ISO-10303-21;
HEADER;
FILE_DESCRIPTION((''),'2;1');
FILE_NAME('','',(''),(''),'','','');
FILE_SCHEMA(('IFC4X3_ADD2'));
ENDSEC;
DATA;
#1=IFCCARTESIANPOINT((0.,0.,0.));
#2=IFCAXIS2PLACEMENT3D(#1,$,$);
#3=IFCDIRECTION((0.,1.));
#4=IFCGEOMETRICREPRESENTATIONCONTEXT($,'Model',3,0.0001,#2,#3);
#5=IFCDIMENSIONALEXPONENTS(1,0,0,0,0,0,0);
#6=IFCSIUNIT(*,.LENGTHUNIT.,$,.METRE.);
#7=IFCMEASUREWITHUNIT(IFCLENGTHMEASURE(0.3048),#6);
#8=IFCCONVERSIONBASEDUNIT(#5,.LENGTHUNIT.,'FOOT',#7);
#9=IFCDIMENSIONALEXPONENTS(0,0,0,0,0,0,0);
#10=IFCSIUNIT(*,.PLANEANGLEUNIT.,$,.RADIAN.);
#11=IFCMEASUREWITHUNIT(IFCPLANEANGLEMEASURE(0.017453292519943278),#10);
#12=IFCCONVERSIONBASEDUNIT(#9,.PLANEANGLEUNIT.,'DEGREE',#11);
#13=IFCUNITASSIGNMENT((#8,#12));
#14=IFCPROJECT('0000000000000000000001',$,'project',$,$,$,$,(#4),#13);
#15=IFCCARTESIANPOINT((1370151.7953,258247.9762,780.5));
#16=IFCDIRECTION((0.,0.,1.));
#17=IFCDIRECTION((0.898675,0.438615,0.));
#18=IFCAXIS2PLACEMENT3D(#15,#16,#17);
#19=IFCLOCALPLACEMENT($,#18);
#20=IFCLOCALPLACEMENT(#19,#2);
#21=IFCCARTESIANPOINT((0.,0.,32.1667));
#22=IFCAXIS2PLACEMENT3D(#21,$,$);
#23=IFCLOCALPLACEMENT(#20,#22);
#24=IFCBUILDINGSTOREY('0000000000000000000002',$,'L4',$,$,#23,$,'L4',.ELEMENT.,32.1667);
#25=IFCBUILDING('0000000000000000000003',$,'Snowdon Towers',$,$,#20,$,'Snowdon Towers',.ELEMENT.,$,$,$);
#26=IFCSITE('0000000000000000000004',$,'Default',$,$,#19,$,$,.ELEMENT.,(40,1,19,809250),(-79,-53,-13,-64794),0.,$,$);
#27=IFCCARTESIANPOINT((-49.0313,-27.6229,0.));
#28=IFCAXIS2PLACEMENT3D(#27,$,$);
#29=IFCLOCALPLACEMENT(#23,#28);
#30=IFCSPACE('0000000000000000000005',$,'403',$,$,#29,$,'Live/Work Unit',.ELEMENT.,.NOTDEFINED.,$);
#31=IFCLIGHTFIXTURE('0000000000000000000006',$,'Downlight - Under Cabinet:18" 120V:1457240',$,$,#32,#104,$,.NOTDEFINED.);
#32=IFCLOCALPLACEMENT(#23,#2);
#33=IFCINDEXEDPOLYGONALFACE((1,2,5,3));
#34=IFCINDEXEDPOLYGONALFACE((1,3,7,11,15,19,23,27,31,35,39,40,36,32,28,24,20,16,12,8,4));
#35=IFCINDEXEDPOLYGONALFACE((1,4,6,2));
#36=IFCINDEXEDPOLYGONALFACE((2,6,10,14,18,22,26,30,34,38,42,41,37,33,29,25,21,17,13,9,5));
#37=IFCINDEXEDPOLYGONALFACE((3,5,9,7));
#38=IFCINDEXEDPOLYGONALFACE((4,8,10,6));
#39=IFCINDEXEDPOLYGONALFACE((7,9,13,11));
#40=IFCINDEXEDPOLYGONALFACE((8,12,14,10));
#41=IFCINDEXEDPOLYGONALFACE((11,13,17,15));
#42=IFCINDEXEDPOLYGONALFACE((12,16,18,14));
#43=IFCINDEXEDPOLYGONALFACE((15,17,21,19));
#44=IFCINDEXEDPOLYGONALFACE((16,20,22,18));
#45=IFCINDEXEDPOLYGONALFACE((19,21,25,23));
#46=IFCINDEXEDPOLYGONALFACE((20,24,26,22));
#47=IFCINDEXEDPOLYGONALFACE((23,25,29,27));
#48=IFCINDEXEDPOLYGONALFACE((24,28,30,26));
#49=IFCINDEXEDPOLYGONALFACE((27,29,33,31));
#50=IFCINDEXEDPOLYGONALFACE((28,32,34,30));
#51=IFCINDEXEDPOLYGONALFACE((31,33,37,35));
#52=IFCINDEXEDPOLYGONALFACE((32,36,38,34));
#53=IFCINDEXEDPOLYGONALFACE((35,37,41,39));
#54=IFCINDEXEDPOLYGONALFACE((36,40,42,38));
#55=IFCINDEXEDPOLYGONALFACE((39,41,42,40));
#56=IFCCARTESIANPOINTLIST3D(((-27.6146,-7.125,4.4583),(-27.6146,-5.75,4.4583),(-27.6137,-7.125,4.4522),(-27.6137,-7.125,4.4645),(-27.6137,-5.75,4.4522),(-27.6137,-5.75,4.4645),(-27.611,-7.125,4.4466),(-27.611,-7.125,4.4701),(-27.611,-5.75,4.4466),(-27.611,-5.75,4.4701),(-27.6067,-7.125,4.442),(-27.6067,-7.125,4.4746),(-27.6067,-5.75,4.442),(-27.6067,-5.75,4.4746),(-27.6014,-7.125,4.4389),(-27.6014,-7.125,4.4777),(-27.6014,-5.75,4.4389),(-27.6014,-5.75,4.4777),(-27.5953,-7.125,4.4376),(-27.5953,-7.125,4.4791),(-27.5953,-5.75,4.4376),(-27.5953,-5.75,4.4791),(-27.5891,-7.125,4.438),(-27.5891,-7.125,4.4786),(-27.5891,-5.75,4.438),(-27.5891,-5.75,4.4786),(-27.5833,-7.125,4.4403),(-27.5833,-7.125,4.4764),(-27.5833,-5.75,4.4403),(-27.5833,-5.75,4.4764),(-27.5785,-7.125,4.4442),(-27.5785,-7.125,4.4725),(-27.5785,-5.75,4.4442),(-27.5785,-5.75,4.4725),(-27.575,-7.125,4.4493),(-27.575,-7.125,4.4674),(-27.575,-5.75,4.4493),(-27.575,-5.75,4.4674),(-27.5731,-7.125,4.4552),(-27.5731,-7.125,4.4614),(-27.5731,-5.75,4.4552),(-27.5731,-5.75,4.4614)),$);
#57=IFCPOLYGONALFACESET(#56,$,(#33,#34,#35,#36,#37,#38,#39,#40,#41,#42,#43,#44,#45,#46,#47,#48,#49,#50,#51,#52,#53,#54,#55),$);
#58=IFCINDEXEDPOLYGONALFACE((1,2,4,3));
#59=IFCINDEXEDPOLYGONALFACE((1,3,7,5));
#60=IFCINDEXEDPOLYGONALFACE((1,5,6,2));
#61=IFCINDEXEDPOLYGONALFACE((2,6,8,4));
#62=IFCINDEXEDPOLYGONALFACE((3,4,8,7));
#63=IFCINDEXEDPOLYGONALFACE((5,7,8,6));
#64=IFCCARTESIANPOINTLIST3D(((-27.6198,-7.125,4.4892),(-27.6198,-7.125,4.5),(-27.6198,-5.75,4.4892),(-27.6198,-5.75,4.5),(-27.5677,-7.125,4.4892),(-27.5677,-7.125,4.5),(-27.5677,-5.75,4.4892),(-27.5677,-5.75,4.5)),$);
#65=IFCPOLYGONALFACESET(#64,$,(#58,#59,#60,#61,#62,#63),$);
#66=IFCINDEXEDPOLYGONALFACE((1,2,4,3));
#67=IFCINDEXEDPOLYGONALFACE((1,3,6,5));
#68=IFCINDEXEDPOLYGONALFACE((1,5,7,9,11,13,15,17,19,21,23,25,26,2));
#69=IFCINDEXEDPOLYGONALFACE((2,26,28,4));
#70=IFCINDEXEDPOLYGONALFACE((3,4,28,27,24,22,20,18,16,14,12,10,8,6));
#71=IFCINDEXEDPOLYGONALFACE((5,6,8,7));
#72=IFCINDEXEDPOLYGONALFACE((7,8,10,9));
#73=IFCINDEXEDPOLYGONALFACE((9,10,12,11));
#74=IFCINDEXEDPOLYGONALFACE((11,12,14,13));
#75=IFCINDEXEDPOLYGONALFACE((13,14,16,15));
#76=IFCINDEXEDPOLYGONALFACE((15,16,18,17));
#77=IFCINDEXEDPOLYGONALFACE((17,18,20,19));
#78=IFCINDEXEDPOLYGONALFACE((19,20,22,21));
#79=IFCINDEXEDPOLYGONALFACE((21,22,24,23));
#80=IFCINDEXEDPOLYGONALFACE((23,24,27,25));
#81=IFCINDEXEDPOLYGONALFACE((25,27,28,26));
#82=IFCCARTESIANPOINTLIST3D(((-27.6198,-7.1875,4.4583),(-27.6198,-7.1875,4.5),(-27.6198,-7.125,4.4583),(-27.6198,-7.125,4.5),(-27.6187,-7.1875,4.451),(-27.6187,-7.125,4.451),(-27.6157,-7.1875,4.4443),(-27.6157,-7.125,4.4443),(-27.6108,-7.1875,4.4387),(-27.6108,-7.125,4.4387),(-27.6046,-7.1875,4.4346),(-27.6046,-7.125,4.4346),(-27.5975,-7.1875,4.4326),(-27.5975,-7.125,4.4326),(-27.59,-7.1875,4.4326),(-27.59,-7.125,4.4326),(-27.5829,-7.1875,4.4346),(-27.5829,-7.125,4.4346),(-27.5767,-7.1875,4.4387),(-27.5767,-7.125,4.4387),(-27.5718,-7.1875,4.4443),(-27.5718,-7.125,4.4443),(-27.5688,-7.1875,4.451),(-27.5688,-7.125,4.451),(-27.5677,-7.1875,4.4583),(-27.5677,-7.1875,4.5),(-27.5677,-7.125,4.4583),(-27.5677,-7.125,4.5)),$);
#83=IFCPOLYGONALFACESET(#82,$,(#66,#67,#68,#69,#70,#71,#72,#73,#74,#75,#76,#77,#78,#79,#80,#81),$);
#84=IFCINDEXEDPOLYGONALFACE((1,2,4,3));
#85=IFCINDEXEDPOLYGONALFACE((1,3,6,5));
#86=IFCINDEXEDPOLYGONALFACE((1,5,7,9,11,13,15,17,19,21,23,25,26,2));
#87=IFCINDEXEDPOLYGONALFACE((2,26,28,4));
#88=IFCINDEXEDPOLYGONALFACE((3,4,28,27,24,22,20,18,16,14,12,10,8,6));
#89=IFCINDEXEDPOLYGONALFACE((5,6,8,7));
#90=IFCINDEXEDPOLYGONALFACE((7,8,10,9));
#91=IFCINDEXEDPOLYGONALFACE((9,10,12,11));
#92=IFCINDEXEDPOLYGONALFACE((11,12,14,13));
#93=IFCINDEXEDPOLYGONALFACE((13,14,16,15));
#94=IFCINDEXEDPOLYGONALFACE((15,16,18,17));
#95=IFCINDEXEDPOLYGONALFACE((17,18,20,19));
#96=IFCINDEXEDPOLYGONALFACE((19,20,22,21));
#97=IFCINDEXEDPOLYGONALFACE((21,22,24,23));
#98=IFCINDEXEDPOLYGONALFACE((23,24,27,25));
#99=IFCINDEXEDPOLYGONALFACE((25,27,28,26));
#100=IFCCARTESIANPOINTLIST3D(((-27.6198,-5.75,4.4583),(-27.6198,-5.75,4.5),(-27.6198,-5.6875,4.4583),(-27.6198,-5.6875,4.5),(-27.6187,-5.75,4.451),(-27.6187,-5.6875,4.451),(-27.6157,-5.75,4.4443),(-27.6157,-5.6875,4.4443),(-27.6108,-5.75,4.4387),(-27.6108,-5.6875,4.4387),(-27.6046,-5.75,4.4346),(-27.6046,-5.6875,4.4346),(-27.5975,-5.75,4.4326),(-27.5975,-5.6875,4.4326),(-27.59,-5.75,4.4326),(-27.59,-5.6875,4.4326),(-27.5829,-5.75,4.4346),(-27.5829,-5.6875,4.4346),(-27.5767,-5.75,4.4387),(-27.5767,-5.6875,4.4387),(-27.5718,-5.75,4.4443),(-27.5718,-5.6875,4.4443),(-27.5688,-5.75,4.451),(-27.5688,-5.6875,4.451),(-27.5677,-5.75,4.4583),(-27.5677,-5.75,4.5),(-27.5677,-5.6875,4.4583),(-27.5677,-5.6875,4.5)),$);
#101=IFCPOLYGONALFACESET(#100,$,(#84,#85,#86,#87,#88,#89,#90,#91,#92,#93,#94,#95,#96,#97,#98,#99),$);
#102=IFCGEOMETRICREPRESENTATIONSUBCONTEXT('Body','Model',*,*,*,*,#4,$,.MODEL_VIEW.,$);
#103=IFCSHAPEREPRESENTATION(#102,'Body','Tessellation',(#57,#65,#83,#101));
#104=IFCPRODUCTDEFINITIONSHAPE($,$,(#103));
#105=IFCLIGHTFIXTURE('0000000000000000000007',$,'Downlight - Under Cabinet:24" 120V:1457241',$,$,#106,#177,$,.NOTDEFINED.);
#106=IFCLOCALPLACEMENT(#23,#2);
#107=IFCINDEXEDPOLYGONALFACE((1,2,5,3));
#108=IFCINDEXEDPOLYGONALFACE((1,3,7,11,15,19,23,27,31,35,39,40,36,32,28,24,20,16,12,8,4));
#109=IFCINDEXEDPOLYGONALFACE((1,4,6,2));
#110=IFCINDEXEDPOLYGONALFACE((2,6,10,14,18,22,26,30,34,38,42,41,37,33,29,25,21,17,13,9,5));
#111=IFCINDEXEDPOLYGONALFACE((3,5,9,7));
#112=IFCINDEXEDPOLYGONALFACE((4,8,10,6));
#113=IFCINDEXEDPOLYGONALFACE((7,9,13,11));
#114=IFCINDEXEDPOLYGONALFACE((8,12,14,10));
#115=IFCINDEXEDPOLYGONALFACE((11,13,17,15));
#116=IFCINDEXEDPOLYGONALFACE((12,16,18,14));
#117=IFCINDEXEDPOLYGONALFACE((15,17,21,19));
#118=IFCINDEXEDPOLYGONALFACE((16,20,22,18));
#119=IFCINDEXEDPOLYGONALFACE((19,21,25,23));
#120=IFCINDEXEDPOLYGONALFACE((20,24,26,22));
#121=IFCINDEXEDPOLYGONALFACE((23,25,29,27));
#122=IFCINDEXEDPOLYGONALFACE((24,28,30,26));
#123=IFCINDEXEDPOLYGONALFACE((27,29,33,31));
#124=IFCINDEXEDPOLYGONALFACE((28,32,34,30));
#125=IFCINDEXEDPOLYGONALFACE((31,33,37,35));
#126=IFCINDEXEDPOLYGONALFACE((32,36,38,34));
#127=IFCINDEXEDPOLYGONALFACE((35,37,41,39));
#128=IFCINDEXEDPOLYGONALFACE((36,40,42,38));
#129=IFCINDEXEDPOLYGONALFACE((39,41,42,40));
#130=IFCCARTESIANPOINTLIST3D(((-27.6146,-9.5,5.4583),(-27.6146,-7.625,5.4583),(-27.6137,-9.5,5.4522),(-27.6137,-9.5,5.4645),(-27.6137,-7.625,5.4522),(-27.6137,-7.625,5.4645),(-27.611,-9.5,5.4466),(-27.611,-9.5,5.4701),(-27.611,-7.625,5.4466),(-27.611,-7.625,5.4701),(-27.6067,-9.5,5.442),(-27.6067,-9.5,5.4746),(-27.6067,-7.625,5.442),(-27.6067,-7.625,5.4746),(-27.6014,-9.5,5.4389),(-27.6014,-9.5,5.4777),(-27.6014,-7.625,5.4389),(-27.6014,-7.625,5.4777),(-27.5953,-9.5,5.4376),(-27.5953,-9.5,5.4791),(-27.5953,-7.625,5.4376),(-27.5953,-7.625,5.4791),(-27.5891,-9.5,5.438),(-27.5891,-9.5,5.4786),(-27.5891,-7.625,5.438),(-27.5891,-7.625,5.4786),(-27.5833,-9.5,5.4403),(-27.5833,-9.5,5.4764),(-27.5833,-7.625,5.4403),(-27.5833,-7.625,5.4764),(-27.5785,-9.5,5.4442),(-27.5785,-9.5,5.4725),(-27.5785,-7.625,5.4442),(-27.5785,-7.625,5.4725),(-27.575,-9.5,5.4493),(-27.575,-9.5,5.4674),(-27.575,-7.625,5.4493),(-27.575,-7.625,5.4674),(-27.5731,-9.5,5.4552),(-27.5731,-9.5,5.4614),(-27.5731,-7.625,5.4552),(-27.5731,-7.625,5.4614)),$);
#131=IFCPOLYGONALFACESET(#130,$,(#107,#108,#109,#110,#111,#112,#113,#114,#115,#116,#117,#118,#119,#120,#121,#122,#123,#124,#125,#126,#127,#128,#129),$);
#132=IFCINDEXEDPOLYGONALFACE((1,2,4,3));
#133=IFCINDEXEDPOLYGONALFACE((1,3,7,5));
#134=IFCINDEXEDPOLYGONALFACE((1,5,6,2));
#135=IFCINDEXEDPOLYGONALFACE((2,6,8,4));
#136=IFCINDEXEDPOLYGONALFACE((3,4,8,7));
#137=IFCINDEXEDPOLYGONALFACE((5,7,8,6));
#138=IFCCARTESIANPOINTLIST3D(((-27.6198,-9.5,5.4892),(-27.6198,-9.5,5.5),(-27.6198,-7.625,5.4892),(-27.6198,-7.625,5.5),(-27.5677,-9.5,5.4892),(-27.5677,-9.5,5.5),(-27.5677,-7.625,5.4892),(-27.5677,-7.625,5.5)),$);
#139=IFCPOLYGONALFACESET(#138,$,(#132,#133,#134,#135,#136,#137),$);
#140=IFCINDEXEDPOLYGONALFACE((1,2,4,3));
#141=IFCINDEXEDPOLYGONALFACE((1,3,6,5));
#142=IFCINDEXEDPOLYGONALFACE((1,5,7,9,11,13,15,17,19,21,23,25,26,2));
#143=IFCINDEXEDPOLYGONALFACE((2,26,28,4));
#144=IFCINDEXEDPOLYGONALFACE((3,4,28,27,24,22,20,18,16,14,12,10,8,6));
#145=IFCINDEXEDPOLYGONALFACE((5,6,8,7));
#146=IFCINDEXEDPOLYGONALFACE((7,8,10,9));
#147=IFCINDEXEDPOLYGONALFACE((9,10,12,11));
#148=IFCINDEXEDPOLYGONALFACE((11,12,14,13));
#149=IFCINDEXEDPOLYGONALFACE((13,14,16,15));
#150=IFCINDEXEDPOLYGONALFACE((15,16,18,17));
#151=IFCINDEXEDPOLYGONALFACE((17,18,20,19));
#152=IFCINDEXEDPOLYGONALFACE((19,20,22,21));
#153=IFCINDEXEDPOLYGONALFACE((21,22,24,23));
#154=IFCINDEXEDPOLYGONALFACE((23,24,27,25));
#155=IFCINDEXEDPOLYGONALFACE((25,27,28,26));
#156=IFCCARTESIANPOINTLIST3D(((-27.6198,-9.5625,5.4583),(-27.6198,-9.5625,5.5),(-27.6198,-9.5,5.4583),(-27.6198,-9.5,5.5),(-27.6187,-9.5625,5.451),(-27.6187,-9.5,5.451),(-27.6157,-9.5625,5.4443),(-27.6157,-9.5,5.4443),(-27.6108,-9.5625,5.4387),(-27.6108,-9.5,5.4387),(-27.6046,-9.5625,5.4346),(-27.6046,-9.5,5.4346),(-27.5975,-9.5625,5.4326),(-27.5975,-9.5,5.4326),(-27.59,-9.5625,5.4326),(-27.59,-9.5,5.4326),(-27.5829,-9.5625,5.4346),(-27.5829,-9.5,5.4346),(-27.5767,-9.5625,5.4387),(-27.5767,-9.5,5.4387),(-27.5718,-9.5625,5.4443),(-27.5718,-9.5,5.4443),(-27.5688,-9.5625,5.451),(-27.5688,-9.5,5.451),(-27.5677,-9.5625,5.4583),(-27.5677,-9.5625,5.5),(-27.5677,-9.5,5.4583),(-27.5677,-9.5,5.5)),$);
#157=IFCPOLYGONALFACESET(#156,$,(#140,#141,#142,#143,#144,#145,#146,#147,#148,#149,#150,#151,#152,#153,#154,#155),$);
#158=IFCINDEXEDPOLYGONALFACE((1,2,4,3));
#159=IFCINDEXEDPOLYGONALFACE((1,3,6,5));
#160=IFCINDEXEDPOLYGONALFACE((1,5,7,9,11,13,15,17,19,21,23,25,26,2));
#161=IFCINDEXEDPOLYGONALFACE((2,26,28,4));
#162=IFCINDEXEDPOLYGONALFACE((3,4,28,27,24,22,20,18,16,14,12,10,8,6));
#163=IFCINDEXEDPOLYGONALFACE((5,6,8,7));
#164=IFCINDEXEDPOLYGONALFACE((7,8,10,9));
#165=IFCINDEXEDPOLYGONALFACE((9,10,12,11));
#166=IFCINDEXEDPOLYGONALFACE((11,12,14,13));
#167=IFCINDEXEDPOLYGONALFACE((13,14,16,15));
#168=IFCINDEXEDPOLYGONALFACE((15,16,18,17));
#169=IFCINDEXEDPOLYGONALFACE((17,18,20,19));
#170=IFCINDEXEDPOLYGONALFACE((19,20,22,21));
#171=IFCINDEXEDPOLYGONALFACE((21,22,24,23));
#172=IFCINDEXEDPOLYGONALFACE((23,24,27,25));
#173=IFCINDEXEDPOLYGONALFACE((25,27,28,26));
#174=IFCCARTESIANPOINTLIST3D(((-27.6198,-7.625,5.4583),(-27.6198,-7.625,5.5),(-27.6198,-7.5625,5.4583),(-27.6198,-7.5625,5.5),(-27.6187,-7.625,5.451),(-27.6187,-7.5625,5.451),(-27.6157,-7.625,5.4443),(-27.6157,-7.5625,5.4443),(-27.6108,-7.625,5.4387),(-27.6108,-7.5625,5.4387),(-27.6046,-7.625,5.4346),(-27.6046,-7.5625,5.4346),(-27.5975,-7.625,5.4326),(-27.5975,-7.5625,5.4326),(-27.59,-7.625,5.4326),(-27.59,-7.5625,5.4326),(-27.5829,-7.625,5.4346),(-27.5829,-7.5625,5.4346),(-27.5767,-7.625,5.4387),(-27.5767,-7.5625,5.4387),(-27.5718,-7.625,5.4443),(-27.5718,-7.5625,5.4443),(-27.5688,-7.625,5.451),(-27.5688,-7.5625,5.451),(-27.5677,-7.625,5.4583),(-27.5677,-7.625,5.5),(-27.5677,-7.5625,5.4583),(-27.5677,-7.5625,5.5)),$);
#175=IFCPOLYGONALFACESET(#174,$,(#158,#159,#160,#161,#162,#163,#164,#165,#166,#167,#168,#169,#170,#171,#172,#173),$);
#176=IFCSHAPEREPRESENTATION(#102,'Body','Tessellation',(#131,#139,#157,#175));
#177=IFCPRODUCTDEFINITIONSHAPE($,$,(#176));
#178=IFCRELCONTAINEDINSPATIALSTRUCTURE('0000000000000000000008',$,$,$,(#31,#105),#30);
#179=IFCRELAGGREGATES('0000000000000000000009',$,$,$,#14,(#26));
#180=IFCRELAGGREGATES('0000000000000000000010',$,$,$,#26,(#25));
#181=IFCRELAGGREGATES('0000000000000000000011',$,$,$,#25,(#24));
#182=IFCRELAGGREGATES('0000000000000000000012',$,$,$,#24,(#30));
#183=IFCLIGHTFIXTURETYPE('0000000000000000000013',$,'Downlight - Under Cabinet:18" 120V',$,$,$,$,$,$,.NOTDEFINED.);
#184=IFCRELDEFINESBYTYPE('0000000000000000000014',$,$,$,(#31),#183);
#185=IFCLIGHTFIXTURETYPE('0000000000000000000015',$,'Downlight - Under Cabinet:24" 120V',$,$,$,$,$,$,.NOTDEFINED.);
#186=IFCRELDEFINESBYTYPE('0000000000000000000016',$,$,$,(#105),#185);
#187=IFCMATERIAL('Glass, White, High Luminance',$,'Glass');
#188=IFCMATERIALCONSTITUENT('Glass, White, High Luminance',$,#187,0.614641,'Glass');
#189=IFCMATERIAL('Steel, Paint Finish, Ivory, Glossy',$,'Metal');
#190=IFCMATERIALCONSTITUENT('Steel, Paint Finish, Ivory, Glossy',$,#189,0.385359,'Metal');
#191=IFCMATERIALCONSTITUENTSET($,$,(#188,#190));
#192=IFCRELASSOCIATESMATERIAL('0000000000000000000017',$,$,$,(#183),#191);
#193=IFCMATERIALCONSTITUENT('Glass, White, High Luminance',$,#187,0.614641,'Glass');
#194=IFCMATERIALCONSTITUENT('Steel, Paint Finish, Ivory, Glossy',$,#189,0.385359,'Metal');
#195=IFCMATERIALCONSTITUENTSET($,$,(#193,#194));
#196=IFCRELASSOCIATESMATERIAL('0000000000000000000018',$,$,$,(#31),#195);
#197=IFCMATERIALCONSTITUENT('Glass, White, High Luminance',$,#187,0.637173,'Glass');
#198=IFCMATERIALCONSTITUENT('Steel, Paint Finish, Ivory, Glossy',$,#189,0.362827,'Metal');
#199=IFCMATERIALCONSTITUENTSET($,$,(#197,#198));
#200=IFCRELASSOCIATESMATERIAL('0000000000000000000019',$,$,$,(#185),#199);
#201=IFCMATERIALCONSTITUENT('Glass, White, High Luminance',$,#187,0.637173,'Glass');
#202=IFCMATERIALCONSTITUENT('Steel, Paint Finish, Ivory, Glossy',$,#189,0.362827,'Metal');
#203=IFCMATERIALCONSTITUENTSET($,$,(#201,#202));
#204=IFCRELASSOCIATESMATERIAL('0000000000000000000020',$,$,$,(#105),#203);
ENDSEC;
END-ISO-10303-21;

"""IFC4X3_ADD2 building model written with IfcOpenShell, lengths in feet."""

from ifc_helpers import new_model, entity, si_unit, converted_unit, direction, frame, frame_2d, origin, origin_2d_with_axis, place, context, subcontext, project, spatial, polyline, circle_curve, parameter, trimmed, segment, composite_curve, rectangle, circle, outline, extrude, source, transform, mapped, material, constituent, constituent_set, type_object, type_shapes, element, save


model = new_model("IFC4X3_ADD2")

# Units and contexts
model_context = context("Model", 3, precision=0.0001, world=origin(), true_north=direction((0.0, 1.0)))
body_context = subcontext(model_context, "Body", "Model", "MODEL_VIEW")
ifc_project = project(units=[converted_unit("LENGTHUNIT", "FOOT", entity("IfcLengthMeasure", 0.3048), si_unit("LENGTHUNIT", "METRE"), dimensions=[1, 0, 0, 0, 0, 0, 0]), converted_unit("PLANEANGLEUNIT", "DEGREE", entity("IfcPlaneAngleMeasure", 0.017453292519943278), si_unit("PLANEANGLEUNIT", "RADIAN"), dimensions=[0, 0, 0, 0, 0, 0, 0])], contexts=[model_context])

# Site, building, storey
site_placement = place(None, frame((1370151.7953, 258247.9762, 780.5), z_axis=(0.0, 0.0, 1.0), x_axis=(0.898675, 0.438615, 0.0)))
site = spatial("IfcSite", under=ifc_project, at=site_placement, Name="Default", CompositionType="ELEMENT", RefLatitude=(40, 1, 19, 809250), RefLongitude=(-79, -53, -13, -64794), RefElevation=0.0)
building_placement = place(site_placement, origin())
building = spatial("IfcBuilding", under=site, at=building_placement, Name="Snowdon Towers", LongName="Snowdon Towers", CompositionType="ELEMENT")
storey_placement = place(building_placement, frame((0.0, 0.0, 32.1667)))
storey = spatial("IfcBuildingStorey", under=building, at=storey_placement, Name="L4", LongName="L4", CompositionType="ELEMENT", Elevation=32.1667)

# Shared definitions
space_1_placement = place(storey_placement, frame((-49.0313, -27.6229, 0.0)))
space_1 = spatial("IfcSpace", under=storey, at=space_1_placement, Name="403", LongName="Live/Work Unit", CompositionType="ELEMENT", PredefinedType="NOTDEFINED")

# Light fixtures
ifc_material_1 = material(Name="Glass, White, High Luminance", Category="Glass")
ifc_material_2 = material(Name="Steel, Paint Finish, Ivory, Glossy", Category="Metal")
ifc_constituent_1 = constituent(ifc_material_1, Name="Glass, White, High Luminance", Category="Glass", fraction=0.614641)
ifc_constituent_2 = constituent(ifc_material_2, Name="Steel, Paint Finish, Ivory, Glossy", Category="Metal", fraction=0.385359)
ifc_constituent_set_1 = constituent_set(constituents=[ifc_constituent_1, ifc_constituent_2])
light_fixture_type_1 = type_object("IfcLightFixtureType", Name="Downlight - Under Cabinet:18\" 120V", PredefinedType="NOTDEFINED", material=ifc_constituent_set_1)
shared_shape_1 = source(origin(), body_context, "Body", "SweptSolid", [
    extrude(circle(Radius=0.0208, at=origin_2d_with_axis()), frame((-0.6875, 0.0, 4.4583), z_axis=(1.0, 0.0, 0.0), x_axis=(0.0, 1.0, 0.0)), (0.0, 0.0, 1.0), 1.375),
    extrude(rectangle(XDim=1.375, YDim=0.0521, at=origin_2d_with_axis()), frame((0.0, 0.0, 4.4892), z_axis=(0.0, 0.0, 1.0), x_axis=(-1.0, 0.0, 0.0)), (0.0, 0.0, 1.0), 0.0108),
    extrude(outline(composite_curve([segment(polyline([(-0.026, -0.0208), (0.026, -0.0208)]), True, "CONTINUOUS"), segment(polyline([(0.026, -0.0208), (0.026, 0.0208)]), True, "CONTINUOUS"), segment(trimmed(circle_curve(frame_2d((0.0, 0.0208), x_axis=(0.0, -1.0)), 0.026), [parameter(90.0)], [parameter(270.0)], True, "PARAMETER"), True, "CONTINUOUS"), segment(polyline([(-0.026, 0.0208), (-0.026, -0.0208)]), True, "CONTINUOUS")], self_intersect=False)), frame((-0.75, 0.0, 4.4792), z_axis=(1.0, 0.0, 0.0), x_axis=(0.0, -1.0, 0.0)), (0.0, 0.0, 1.0), 0.0625),
    extrude(outline(composite_curve([segment(polyline([(-0.0208, -0.026), (0.0208, -0.026)]), True, "CONTINUOUS"), segment(trimmed(circle_curve(frame_2d((0.0208, 0.0), x_axis=(0.0, 1.0)), 0.026), [parameter(180.0)], [parameter(360.0)], True, "PARAMETER"), True, "CONTINUOUS"), segment(polyline([(0.0208, 0.026), (-0.0208, 0.026)]), True, "CONTINUOUS"), segment(polyline([(-0.0208, 0.026), (-0.0208, -0.026)]), True, "CONTINUOUS")], self_intersect=False)), frame((0.6875, 0.0, 4.4792), z_axis=(1.0, 0.0, 0.0), x_axis=(0.0, 0.0, -1.0)), (0.0, 0.0, 1.0), 0.0625),
])
type_shapes(light_fixture_type_1, [shared_shape_1])
ifc_constituent_3 = constituent(ifc_material_1, Name="Glass, White, High Luminance", Category="Glass", fraction=0.614641)
ifc_constituent_4 = constituent(ifc_material_2, Name="Steel, Paint Finish, Ivory, Glossy", Category="Metal", fraction=0.385359)
ifc_constituent_set_2 = constituent_set(constituents=[ifc_constituent_3, ifc_constituent_4])
light_fixture_1_placement = place(space_1_placement, frame((21.4375, 21.1854, 0.0), z_axis=(0.0, 0.0, 1.0), x_axis=(0.0, 1.0, 0.0)))
element("IfcLightFixture", 1, at=light_fixture_1_placement, inside=space_1, type_object=light_fixture_type_1, material=ifc_constituent_set_2, Name="Downlight - Under Cabinet:18\" 120V:1457240", PredefinedType="NOTDEFINED", context=body_context, shape_type="MappedRepresentation", body=[
    mapped(shared_shape_1, transform((0.0, 0.0, 0.0), scale=1.0)),
])
ifc_constituent_5 = constituent(ifc_material_1, Name="Glass, White, High Luminance", Category="Glass", fraction=0.637173)
ifc_constituent_6 = constituent(ifc_material_2, Name="Steel, Paint Finish, Ivory, Glossy", Category="Metal", fraction=0.362827)
ifc_constituent_set_3 = constituent_set(constituents=[ifc_constituent_5, ifc_constituent_6])
ifc_constituent_7 = constituent(ifc_material_1, Name="Glass, White, High Luminance", Category="Glass", fraction=0.637173)
ifc_constituent_8 = constituent(ifc_material_2, Name="Steel, Paint Finish, Ivory, Glossy", Category="Metal", fraction=0.362827)
ifc_constituent_set_4 = constituent_set(constituents=[ifc_constituent_7, ifc_constituent_8])
light_fixture_type_2 = type_object("IfcLightFixtureType", Name="Downlight - Under Cabinet:24\" 120V", PredefinedType="NOTDEFINED", material=ifc_constituent_set_4)
shared_shape_2 = source(origin(), body_context, "Body", "SweptSolid", [
    extrude(circle(Radius=0.0208, at=origin_2d_with_axis()), frame((-0.9375, 0.0, 4.4583), z_axis=(1.0, 0.0, 0.0), x_axis=(0.0, 1.0, 0.0)), (0.0, 0.0, 1.0), 1.875),
    extrude(rectangle(XDim=1.875, YDim=0.0521, at=origin_2d_with_axis()), frame((0.0, 0.0, 4.4892), z_axis=(0.0, 0.0, 1.0), x_axis=(-1.0, 0.0, 0.0)), (0.0, 0.0, 1.0), 0.0108),
    extrude(outline(composite_curve([segment(polyline([(-0.026, -0.0208), (0.026, -0.0208)]), True, "CONTINUOUS"), segment(polyline([(0.026, -0.0208), (0.026, 0.0208)]), True, "CONTINUOUS"), segment(trimmed(circle_curve(frame_2d((0.0, 0.0208), x_axis=(0.0, -1.0)), 0.026), [parameter(90.0)], [parameter(270.0)], True, "PARAMETER"), True, "CONTINUOUS"), segment(polyline([(-0.026, 0.0208), (-0.026, -0.0208)]), True, "CONTINUOUS")], self_intersect=False)), frame((-1.0, 0.0, 4.4792), z_axis=(1.0, 0.0, 0.0), x_axis=(0.0, -1.0, 0.0)), (0.0, 0.0, 1.0), 0.0625),
    extrude(outline(composite_curve([segment(polyline([(-0.0208, -0.026), (0.0208, -0.026)]), True, "CONTINUOUS"), segment(trimmed(circle_curve(frame_2d((0.0208, 0.0), x_axis=(0.0, 1.0)), 0.026), [parameter(180.0)], [parameter(360.0)], True, "PARAMETER"), True, "CONTINUOUS"), segment(polyline([(0.0208, 0.026), (-0.0208, 0.026)]), True, "CONTINUOUS"), segment(polyline([(-0.0208, 0.026), (-0.0208, -0.026)]), True, "CONTINUOUS")], self_intersect=False)), frame((0.9375, 0.0, 4.4792), z_axis=(1.0, 0.0, 0.0), x_axis=(0.0, 0.0, -1.0)), (0.0, 0.0, 1.0), 0.0625),
])
type_shapes(light_fixture_type_2, [shared_shape_2])
light_fixture_2_placement = place(space_1_placement, frame((21.4375, 19.0604, 1.0), z_axis=(0.0, 0.0, 1.0), x_axis=(0.0, 1.0, 0.0)))
element("IfcLightFixture", 2, at=light_fixture_2_placement, inside=space_1, type_object=light_fixture_type_2, material=ifc_constituent_set_3, Name="Downlight - Under Cabinet:24\" 120V:1457241", PredefinedType="NOTDEFINED", context=body_context, shape_type="MappedRepresentation", body=[
    mapped(shared_shape_2, transform((0.0, 0.0, 0.0), scale=1.0)),
])

save(model, "model.ifc")
